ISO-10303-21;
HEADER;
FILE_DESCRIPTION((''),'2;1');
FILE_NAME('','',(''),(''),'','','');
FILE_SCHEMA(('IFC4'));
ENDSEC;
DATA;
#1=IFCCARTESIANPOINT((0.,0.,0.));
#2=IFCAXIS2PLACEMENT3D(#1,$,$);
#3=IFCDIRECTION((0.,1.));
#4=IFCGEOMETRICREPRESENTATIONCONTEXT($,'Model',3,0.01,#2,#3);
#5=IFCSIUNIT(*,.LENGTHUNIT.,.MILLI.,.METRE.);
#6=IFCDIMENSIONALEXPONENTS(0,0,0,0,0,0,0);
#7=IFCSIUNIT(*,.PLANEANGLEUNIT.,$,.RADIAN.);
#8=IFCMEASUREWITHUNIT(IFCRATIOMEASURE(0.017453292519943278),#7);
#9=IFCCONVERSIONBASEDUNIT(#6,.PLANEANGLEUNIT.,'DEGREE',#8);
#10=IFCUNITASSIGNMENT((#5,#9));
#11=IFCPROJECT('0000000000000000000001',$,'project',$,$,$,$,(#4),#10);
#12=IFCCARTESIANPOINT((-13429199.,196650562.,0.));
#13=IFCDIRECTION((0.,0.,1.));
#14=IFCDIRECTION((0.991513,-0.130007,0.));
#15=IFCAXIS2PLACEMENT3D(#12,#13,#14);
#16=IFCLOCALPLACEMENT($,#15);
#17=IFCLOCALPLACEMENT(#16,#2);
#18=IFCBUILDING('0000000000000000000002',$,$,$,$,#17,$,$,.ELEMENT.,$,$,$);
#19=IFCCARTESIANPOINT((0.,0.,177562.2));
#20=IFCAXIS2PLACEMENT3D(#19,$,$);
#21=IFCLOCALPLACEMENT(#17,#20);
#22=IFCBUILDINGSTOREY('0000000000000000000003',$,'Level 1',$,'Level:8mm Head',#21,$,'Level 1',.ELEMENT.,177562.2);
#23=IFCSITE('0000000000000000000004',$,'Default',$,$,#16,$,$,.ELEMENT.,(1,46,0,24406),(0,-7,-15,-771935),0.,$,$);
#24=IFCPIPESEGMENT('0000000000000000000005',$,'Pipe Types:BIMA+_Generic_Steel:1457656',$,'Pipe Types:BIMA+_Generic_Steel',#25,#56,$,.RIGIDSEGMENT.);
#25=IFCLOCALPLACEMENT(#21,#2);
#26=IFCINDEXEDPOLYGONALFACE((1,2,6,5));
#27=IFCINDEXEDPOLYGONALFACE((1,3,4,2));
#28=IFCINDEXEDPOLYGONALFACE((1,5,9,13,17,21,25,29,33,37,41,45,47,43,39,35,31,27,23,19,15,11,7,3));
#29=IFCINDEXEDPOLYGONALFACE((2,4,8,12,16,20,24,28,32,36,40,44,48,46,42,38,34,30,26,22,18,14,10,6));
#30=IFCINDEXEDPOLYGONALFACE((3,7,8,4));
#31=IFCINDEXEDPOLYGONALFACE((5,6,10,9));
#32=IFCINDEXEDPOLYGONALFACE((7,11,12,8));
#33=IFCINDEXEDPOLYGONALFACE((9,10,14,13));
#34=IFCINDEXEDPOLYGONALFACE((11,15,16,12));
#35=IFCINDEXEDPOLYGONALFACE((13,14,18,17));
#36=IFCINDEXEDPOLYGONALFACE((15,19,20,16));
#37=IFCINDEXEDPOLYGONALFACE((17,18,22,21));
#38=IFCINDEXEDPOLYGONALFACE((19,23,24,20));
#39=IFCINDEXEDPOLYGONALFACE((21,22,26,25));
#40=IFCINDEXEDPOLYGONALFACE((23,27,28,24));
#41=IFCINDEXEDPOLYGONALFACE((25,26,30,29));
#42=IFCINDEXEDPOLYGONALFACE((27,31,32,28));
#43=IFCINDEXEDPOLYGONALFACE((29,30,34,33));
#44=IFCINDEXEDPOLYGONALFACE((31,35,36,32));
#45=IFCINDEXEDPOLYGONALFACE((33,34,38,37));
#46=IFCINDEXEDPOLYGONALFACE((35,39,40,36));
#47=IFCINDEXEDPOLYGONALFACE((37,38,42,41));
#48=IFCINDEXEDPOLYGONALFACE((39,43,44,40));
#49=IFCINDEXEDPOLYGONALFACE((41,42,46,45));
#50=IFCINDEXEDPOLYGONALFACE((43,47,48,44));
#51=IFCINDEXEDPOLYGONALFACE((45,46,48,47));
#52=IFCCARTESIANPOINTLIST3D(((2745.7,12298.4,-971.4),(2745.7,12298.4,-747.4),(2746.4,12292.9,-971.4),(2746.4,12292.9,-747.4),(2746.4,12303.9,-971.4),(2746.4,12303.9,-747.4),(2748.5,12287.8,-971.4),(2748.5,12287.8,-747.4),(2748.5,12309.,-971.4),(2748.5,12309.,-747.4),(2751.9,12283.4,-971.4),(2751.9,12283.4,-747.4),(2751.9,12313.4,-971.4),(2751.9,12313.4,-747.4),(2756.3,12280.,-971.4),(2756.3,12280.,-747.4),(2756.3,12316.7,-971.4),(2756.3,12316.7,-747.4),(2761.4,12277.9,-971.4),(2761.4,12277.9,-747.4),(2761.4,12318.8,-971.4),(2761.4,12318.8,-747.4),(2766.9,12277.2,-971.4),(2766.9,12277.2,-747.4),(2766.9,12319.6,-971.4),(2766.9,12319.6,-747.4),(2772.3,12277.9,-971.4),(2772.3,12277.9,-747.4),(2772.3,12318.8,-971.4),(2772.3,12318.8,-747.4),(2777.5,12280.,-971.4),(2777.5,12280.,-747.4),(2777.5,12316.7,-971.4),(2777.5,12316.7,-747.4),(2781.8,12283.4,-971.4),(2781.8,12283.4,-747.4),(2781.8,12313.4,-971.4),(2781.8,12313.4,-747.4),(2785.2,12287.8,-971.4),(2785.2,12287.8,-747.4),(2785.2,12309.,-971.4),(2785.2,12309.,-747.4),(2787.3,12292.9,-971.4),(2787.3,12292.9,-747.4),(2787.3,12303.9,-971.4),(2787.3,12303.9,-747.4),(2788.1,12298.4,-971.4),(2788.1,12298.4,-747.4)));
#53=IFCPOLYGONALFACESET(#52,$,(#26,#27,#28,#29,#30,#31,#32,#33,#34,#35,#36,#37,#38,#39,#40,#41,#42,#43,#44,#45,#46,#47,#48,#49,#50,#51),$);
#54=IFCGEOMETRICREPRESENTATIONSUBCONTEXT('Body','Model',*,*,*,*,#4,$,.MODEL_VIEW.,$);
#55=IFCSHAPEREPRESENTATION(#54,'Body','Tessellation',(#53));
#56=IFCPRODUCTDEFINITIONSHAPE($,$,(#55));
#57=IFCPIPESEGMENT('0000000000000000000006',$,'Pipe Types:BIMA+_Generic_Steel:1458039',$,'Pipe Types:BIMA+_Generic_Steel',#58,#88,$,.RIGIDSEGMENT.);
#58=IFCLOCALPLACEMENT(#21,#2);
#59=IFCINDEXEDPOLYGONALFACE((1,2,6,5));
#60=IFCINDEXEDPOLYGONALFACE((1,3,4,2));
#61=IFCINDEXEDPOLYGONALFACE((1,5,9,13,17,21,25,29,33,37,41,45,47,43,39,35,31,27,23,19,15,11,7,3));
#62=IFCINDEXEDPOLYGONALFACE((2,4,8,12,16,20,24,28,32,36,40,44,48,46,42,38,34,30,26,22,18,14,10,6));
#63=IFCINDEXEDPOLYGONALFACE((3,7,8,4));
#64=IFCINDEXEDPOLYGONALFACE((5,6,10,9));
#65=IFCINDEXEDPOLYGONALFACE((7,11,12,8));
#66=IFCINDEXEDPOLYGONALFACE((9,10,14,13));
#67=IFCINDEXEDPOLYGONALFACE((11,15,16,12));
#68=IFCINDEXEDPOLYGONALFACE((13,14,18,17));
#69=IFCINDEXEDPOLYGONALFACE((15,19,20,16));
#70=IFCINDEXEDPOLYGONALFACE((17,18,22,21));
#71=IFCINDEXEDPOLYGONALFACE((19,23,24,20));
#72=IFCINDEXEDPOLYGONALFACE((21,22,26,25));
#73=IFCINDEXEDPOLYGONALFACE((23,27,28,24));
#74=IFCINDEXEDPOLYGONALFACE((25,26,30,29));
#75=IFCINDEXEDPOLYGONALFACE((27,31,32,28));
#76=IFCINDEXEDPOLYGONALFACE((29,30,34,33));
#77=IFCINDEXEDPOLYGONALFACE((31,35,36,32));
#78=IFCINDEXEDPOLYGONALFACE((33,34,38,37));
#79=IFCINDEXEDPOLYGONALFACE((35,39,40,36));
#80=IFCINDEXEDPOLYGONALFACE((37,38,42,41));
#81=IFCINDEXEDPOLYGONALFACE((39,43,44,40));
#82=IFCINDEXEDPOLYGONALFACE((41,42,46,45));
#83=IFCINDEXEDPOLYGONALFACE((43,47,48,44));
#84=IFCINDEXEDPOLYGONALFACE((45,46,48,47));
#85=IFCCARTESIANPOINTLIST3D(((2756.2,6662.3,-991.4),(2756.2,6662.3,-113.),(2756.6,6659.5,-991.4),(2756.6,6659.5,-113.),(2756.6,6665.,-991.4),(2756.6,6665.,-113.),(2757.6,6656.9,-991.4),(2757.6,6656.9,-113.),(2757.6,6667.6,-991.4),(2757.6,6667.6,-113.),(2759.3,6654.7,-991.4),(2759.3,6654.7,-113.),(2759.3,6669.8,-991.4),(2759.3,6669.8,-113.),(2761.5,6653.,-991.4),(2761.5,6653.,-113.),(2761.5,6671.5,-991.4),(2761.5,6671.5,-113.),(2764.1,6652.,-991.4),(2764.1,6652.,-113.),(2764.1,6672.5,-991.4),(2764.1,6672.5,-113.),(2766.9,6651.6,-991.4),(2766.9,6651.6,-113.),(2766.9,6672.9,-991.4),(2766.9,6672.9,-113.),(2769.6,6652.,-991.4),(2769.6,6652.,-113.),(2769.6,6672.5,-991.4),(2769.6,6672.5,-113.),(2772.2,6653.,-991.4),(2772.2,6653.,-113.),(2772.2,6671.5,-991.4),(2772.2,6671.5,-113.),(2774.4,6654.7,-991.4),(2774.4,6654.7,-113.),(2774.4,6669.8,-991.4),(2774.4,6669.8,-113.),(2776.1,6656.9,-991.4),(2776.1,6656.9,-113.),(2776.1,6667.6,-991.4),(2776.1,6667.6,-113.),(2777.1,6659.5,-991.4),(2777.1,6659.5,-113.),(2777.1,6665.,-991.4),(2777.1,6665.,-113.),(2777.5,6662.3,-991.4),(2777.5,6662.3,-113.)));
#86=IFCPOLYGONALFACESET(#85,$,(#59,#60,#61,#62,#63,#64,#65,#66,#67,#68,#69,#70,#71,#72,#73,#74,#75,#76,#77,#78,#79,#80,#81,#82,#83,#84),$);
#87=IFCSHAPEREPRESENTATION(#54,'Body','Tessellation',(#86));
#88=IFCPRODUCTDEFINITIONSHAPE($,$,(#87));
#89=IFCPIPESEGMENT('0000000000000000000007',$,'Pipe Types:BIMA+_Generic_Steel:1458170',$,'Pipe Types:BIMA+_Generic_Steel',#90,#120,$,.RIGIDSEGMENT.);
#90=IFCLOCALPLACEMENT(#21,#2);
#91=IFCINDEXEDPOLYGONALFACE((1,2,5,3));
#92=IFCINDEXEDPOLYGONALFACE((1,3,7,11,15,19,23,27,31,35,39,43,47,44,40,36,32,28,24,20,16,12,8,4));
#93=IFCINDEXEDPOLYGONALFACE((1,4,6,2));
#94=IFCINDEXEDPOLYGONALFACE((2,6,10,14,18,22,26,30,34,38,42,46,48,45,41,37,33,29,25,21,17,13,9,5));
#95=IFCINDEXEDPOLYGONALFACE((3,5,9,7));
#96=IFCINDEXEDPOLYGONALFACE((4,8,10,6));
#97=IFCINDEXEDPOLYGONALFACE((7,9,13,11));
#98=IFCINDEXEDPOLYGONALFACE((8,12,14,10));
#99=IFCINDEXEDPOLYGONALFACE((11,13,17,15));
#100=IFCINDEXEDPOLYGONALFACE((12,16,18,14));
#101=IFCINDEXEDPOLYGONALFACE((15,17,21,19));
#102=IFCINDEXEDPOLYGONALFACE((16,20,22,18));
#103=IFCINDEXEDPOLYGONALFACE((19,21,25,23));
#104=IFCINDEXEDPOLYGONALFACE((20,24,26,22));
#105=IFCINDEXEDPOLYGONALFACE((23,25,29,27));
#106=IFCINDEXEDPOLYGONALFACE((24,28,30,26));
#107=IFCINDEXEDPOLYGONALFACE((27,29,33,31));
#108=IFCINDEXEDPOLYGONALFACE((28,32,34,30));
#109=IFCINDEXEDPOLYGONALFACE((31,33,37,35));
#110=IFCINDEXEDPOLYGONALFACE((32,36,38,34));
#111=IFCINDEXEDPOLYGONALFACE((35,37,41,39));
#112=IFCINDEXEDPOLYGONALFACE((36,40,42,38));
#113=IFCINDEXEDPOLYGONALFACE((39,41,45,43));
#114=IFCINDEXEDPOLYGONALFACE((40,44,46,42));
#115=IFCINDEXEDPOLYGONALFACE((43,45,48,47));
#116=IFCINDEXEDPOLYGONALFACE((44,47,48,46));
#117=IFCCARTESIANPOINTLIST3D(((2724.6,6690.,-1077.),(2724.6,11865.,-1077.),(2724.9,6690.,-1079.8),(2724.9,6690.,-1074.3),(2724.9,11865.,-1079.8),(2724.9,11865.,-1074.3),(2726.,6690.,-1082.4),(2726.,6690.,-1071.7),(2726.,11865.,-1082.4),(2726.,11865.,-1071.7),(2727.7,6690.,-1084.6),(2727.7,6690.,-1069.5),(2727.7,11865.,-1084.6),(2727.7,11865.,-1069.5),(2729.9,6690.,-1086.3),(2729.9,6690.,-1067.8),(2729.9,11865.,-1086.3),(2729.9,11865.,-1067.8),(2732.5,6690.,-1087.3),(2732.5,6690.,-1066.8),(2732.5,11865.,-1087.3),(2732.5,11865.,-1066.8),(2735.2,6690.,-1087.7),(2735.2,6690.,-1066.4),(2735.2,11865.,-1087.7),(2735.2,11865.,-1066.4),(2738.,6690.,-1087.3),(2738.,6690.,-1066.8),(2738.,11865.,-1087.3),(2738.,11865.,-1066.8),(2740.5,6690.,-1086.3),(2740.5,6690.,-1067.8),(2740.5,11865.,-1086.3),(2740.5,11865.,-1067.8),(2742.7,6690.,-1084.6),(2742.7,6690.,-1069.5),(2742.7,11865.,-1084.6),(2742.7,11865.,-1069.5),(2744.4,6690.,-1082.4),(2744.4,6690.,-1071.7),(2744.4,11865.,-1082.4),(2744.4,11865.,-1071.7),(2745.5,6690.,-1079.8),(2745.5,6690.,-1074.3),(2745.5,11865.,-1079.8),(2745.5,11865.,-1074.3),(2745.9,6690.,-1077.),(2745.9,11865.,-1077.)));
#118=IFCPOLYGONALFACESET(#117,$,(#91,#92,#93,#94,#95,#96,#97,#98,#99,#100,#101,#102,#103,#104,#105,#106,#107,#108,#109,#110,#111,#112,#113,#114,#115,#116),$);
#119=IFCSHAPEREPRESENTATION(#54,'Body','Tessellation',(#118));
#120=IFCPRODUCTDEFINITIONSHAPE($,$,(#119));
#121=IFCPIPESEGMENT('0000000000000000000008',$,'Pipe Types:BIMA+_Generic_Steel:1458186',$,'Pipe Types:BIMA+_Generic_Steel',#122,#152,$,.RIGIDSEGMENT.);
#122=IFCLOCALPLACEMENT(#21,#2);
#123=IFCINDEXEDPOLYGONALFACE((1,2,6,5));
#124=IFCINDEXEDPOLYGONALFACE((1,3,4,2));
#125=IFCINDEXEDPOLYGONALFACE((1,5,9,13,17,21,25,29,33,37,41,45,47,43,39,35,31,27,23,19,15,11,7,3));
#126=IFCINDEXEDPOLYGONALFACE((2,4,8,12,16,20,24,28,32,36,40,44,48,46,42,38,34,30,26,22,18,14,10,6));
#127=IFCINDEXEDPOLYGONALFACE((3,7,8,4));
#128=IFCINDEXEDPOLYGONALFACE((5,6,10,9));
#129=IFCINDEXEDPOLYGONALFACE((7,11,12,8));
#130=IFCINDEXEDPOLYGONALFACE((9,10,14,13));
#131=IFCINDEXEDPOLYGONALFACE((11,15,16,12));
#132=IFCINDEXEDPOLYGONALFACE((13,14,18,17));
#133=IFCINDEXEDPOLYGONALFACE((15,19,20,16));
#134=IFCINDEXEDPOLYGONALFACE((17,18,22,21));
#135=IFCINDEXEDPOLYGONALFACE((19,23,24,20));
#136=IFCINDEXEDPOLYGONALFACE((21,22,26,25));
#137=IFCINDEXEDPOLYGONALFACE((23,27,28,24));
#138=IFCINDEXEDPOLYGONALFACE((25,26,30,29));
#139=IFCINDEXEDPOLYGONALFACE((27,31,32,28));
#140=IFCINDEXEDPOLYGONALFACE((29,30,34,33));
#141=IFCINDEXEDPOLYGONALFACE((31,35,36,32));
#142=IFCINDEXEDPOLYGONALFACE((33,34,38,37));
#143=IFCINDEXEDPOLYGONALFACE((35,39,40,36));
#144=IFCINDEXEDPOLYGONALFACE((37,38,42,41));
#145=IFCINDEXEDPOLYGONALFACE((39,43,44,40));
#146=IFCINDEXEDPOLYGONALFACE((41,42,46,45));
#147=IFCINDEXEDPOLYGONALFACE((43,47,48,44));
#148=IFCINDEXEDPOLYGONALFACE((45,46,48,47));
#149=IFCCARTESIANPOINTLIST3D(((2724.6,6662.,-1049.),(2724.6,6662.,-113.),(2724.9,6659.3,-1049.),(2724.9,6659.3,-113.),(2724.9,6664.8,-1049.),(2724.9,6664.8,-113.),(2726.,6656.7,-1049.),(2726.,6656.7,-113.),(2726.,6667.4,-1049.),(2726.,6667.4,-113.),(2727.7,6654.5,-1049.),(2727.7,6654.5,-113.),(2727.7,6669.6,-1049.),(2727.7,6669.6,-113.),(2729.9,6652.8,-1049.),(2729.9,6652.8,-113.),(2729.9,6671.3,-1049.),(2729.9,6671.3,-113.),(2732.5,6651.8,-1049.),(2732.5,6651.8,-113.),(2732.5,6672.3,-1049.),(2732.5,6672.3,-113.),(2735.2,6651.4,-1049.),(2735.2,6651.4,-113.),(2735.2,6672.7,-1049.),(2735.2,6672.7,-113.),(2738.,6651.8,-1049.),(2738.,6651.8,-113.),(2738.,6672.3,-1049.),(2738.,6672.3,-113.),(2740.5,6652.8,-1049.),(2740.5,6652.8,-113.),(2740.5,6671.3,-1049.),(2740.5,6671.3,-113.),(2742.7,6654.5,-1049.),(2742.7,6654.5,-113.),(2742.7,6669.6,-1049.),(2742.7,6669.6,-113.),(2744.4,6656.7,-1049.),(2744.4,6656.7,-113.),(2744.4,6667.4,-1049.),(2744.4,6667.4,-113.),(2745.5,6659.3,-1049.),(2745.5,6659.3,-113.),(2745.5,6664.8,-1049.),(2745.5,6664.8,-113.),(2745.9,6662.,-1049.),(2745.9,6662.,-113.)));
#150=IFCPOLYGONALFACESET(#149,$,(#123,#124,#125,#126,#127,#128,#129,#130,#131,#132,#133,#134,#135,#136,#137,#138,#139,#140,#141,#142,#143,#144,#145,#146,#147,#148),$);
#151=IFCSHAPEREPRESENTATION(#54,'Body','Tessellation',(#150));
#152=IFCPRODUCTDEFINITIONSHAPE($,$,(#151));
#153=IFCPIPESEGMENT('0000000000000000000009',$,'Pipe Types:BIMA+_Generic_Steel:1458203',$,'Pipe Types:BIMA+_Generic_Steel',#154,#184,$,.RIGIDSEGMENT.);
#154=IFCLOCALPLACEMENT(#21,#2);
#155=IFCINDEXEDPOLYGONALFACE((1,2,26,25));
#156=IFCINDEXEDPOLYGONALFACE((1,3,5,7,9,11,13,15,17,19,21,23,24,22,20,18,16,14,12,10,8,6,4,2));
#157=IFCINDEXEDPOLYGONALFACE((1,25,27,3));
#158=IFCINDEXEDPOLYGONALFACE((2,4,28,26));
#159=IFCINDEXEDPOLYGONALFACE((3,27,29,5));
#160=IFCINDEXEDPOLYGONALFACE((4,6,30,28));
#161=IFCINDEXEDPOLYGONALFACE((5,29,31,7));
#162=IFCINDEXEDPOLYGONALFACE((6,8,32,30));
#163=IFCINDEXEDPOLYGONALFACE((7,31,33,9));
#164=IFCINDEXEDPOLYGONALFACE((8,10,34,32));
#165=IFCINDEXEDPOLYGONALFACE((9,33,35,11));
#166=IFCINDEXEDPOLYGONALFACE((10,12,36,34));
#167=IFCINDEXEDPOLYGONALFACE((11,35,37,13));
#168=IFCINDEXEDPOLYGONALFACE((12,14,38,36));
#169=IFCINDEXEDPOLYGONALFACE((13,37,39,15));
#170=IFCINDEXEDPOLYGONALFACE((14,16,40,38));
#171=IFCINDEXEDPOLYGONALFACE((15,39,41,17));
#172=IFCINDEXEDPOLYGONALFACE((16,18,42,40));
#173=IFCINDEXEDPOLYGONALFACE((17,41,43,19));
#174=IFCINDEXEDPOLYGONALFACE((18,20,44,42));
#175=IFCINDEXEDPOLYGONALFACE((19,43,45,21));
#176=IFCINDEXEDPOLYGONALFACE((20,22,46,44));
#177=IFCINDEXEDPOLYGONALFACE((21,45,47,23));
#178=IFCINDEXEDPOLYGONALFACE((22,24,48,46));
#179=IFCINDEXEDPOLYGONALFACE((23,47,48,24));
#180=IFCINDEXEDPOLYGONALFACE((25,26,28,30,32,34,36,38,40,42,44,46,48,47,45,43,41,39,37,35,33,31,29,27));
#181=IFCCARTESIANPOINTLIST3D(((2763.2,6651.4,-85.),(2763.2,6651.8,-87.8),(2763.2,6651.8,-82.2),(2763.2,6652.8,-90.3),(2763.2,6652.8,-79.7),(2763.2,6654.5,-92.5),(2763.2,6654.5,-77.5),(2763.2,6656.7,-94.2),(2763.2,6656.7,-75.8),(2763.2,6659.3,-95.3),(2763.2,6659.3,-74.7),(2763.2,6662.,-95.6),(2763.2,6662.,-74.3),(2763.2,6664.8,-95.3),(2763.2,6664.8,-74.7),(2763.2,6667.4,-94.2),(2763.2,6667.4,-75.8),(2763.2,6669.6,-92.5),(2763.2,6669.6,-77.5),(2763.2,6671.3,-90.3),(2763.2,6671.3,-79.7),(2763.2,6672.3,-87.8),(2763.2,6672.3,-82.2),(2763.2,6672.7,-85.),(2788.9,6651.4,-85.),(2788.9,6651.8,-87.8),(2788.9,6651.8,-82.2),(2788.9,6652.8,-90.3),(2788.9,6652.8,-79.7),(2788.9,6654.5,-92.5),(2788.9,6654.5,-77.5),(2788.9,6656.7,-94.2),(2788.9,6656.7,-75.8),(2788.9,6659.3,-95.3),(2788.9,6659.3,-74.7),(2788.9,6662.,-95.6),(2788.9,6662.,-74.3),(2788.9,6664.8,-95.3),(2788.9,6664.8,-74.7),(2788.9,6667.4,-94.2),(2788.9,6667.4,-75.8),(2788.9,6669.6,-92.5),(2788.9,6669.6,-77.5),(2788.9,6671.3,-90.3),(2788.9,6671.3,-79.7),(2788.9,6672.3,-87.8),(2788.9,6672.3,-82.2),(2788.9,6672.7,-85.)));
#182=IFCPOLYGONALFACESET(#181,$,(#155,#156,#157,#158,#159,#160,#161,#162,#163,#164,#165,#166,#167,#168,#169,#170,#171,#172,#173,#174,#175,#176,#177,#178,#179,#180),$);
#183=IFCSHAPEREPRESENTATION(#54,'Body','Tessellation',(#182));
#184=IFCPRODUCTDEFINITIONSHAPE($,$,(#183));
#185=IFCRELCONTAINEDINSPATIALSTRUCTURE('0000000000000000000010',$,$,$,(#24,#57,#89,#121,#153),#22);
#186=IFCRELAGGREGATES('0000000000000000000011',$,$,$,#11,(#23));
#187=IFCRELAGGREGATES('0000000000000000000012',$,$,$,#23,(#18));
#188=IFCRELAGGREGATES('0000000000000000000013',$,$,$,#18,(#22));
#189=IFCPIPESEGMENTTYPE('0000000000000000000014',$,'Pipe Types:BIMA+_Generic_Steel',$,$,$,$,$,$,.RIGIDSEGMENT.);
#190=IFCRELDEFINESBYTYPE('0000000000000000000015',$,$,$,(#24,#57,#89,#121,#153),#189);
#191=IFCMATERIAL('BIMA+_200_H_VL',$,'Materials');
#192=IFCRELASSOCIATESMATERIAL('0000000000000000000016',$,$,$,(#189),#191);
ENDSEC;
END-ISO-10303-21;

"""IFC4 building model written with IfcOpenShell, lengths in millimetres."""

from ifc_helpers import new_model, entity, si_unit, converted_unit, direction, frame, origin, place, context, subcontext, project, spatial, arc, indexed_curve, outline, extrude, material, type_object, element, save


model = new_model("IFC4")

# Units and contexts
model_context = context("Model", 3, precision=0.01, world=origin(), true_north=direction((0.0, 1.0)))
body_context = subcontext(model_context, "Body", "Model", "MODEL_VIEW")
ifc_project = project(units=[si_unit("LENGTHUNIT", "METRE", prefix="MILLI"), converted_unit("PLANEANGLEUNIT", "DEGREE", entity("IfcRatioMeasure", 0.017453292519943278), si_unit("PLANEANGLEUNIT", "RADIAN"), dimensions=[0, 0, 0, 0, 0, 0, 0])], contexts=[model_context])

# Site, building, storey
site_placement = place(None, frame((-13429199.0, 196650562.0, 0.0), z_axis=(0.0, 0.0, 1.0), x_axis=(0.991513, -0.130007, 0.0)))
site = spatial("IfcSite", under=ifc_project, at=site_placement, Name="Default", CompositionType="ELEMENT", RefLatitude=(1, 46, 0, 24406), RefLongitude=(0, -7, -15, -771935), RefElevation=0.0)
building_placement = place(site_placement, origin())
building = spatial("IfcBuilding", under=site, at=building_placement, CompositionType="ELEMENT")
storey_placement = place(building_placement, frame((0.0, 0.0, 177562.2)))
storey = spatial("IfcBuildingStorey", under=building, at=storey_placement, Name="Level 1", ObjectType="Level:8mm Head", LongName="Level 1", CompositionType="ELEMENT", Elevation=177562.2)

# Pipe segments
ifc_material_1 = material(Name="BIMA+_200_H_VL", Category="Materials")
pipe_segment_type_1 = type_object("IfcPipeSegmentType", Name="Pipe Types:BIMA+_Generic_Steel", PredefinedType="RIGIDSEGMENT", material=ifc_material_1)
pipe_segment_1_placement = place(storey_placement, frame((2744.1, 12275.6, -747.4)))
element("IfcPipeSegment", 1, at=pipe_segment_1_placement, inside=storey, type_object=pipe_segment_type_1, Name="Pipe Types:BIMA+_Generic_Steel:1457656", ObjectType="Pipe Types:BIMA+_Generic_Steel", PredefinedType="RIGIDSEGMENT", context=body_context, shape_type="SweptSolid", body=[
    extrude(outline(indexed_curve([(21.2, 0.0), (15.0, 15.0), (0.0, 21.2), (-15.0, 15.0), (-21.2, 0.0), (-15.0, -15.0), (0.0, -21.2), (15.0, -15.0)], segments=[arc(1, 2, 3), arc(3, 4, 5), arc(5, 6, 7), arc(7, 8, 1)], self_intersect=False)), frame((22.8, 22.8, -224.0), z_axis=(0.0, 0.0, 1.0), x_axis=(-1.0, 0.0, 0.0)), (0.0, 0.0, 1.0), 224.0),
])
pipe_segment_2_placement = place(storey_placement, frame((2754.6, 6650.0, -113.0)))
element("IfcPipeSegment", 2, at=pipe_segment_2_placement, inside=storey, type_object=pipe_segment_type_1, Name="Pipe Types:BIMA+_Generic_Steel:1458039", ObjectType="Pipe Types:BIMA+_Generic_Steel", PredefinedType="RIGIDSEGMENT", context=body_context, shape_type="SweptSolid", body=[
    extrude(outline(indexed_curve([(10.6, 0.0), (7.5, 7.5), (0.0, 10.6), (-7.5, 7.5), (-10.6, 0.0), (-7.5, -7.5), (0.0, -10.6), (7.5, -7.5)], segments=[arc(1, 2, 3), arc(3, 4, 5), arc(5, 6, 7), arc(7, 8, 1)], self_intersect=False)), frame((12.2, 12.2, -878.4)), (0.0, 0.0, 1.0), 878.4),
])
pipe_segment_3_placement = place(storey_placement, frame((2723.0, 6690.0, -1089.3)))
element("IfcPipeSegment", 3, at=pipe_segment_3_placement, inside=storey, type_object=pipe_segment_type_1, Name="Pipe Types:BIMA+_Generic_Steel:1458170", ObjectType="Pipe Types:BIMA+_Generic_Steel", PredefinedType="RIGIDSEGMENT", context=body_context, shape_type="SweptSolid", body=[
    extrude(outline(indexed_curve([(10.7, 0.0), (7.5, 7.5), (0.0, 10.7), (-7.5, 7.5), (-10.6, 0.0), (-7.5, -7.5), (0.0, -10.7), (7.5, -7.5)], segments=[arc(1, 2, 3), arc(3, 4, 5), arc(5, 6, 7), arc(7, 8, 1)], self_intersect=False)), frame((12.2, 0.0, 12.2), z_axis=(0.0, 1.0, 0.0), x_axis=(-1.0, 0.0, 0.0)), (0.0, 0.0, 1.0), 5175.0),
])
pipe_segment_4_placement = place(storey_placement, frame((2723.0, 6649.8, -1049.0)))
element("IfcPipeSegment", 4, at=pipe_segment_4_placement, inside=storey, type_object=pipe_segment_type_1, Name="Pipe Types:BIMA+_Generic_Steel:1458186", ObjectType="Pipe Types:BIMA+_Generic_Steel", PredefinedType="RIGIDSEGMENT", context=body_context, shape_type="SweptSolid", body=[
    extrude(outline(indexed_curve([(10.6, 0.0), (7.5, 7.5), (0.0, 10.6), (-7.5, 7.5), (-10.6, 0.0), (-7.5, -7.5), (0.0, -10.6), (7.5, -7.5)], segments=[arc(1, 2, 3), arc(3, 4, 5), arc(5, 6, 7), arc(7, 8, 1)], self_intersect=False)), frame((12.2, 12.2, 0.0), z_axis=(0.0, 0.0, 1.0), x_axis=(-1.0, 0.0, 0.0)), (0.0, 0.0, 1.0), 936.0),
])
pipe_segment_5_placement = place(storey_placement, frame((2763.2, 6649.8, -97.2)))
element("IfcPipeSegment", 5, at=pipe_segment_5_placement, inside=storey, type_object=pipe_segment_type_1, Name="Pipe Types:BIMA+_Generic_Steel:1458203", ObjectType="Pipe Types:BIMA+_Generic_Steel", PredefinedType="RIGIDSEGMENT", context=body_context, shape_type="SweptSolid", body=[
    extrude(outline(indexed_curve([(10.6, 0.0), (7.5, 7.5), (0.0, 10.7), (-7.5, 7.5), (-10.6, 0.0), (-7.5, -7.5), (0.0, -10.7), (7.5, -7.5)], segments=[arc(1, 2, 3), arc(3, 4, 5), arc(5, 6, 7), arc(7, 8, 1)], self_intersect=False)), frame((0.0, 12.2, 12.2), z_axis=(1.0, 0.0, 0.0), x_axis=(0.0, -1.0, 0.0)), (0.0, 0.0, 1.0), 25.6),
])

save(model, "model.ifc")
